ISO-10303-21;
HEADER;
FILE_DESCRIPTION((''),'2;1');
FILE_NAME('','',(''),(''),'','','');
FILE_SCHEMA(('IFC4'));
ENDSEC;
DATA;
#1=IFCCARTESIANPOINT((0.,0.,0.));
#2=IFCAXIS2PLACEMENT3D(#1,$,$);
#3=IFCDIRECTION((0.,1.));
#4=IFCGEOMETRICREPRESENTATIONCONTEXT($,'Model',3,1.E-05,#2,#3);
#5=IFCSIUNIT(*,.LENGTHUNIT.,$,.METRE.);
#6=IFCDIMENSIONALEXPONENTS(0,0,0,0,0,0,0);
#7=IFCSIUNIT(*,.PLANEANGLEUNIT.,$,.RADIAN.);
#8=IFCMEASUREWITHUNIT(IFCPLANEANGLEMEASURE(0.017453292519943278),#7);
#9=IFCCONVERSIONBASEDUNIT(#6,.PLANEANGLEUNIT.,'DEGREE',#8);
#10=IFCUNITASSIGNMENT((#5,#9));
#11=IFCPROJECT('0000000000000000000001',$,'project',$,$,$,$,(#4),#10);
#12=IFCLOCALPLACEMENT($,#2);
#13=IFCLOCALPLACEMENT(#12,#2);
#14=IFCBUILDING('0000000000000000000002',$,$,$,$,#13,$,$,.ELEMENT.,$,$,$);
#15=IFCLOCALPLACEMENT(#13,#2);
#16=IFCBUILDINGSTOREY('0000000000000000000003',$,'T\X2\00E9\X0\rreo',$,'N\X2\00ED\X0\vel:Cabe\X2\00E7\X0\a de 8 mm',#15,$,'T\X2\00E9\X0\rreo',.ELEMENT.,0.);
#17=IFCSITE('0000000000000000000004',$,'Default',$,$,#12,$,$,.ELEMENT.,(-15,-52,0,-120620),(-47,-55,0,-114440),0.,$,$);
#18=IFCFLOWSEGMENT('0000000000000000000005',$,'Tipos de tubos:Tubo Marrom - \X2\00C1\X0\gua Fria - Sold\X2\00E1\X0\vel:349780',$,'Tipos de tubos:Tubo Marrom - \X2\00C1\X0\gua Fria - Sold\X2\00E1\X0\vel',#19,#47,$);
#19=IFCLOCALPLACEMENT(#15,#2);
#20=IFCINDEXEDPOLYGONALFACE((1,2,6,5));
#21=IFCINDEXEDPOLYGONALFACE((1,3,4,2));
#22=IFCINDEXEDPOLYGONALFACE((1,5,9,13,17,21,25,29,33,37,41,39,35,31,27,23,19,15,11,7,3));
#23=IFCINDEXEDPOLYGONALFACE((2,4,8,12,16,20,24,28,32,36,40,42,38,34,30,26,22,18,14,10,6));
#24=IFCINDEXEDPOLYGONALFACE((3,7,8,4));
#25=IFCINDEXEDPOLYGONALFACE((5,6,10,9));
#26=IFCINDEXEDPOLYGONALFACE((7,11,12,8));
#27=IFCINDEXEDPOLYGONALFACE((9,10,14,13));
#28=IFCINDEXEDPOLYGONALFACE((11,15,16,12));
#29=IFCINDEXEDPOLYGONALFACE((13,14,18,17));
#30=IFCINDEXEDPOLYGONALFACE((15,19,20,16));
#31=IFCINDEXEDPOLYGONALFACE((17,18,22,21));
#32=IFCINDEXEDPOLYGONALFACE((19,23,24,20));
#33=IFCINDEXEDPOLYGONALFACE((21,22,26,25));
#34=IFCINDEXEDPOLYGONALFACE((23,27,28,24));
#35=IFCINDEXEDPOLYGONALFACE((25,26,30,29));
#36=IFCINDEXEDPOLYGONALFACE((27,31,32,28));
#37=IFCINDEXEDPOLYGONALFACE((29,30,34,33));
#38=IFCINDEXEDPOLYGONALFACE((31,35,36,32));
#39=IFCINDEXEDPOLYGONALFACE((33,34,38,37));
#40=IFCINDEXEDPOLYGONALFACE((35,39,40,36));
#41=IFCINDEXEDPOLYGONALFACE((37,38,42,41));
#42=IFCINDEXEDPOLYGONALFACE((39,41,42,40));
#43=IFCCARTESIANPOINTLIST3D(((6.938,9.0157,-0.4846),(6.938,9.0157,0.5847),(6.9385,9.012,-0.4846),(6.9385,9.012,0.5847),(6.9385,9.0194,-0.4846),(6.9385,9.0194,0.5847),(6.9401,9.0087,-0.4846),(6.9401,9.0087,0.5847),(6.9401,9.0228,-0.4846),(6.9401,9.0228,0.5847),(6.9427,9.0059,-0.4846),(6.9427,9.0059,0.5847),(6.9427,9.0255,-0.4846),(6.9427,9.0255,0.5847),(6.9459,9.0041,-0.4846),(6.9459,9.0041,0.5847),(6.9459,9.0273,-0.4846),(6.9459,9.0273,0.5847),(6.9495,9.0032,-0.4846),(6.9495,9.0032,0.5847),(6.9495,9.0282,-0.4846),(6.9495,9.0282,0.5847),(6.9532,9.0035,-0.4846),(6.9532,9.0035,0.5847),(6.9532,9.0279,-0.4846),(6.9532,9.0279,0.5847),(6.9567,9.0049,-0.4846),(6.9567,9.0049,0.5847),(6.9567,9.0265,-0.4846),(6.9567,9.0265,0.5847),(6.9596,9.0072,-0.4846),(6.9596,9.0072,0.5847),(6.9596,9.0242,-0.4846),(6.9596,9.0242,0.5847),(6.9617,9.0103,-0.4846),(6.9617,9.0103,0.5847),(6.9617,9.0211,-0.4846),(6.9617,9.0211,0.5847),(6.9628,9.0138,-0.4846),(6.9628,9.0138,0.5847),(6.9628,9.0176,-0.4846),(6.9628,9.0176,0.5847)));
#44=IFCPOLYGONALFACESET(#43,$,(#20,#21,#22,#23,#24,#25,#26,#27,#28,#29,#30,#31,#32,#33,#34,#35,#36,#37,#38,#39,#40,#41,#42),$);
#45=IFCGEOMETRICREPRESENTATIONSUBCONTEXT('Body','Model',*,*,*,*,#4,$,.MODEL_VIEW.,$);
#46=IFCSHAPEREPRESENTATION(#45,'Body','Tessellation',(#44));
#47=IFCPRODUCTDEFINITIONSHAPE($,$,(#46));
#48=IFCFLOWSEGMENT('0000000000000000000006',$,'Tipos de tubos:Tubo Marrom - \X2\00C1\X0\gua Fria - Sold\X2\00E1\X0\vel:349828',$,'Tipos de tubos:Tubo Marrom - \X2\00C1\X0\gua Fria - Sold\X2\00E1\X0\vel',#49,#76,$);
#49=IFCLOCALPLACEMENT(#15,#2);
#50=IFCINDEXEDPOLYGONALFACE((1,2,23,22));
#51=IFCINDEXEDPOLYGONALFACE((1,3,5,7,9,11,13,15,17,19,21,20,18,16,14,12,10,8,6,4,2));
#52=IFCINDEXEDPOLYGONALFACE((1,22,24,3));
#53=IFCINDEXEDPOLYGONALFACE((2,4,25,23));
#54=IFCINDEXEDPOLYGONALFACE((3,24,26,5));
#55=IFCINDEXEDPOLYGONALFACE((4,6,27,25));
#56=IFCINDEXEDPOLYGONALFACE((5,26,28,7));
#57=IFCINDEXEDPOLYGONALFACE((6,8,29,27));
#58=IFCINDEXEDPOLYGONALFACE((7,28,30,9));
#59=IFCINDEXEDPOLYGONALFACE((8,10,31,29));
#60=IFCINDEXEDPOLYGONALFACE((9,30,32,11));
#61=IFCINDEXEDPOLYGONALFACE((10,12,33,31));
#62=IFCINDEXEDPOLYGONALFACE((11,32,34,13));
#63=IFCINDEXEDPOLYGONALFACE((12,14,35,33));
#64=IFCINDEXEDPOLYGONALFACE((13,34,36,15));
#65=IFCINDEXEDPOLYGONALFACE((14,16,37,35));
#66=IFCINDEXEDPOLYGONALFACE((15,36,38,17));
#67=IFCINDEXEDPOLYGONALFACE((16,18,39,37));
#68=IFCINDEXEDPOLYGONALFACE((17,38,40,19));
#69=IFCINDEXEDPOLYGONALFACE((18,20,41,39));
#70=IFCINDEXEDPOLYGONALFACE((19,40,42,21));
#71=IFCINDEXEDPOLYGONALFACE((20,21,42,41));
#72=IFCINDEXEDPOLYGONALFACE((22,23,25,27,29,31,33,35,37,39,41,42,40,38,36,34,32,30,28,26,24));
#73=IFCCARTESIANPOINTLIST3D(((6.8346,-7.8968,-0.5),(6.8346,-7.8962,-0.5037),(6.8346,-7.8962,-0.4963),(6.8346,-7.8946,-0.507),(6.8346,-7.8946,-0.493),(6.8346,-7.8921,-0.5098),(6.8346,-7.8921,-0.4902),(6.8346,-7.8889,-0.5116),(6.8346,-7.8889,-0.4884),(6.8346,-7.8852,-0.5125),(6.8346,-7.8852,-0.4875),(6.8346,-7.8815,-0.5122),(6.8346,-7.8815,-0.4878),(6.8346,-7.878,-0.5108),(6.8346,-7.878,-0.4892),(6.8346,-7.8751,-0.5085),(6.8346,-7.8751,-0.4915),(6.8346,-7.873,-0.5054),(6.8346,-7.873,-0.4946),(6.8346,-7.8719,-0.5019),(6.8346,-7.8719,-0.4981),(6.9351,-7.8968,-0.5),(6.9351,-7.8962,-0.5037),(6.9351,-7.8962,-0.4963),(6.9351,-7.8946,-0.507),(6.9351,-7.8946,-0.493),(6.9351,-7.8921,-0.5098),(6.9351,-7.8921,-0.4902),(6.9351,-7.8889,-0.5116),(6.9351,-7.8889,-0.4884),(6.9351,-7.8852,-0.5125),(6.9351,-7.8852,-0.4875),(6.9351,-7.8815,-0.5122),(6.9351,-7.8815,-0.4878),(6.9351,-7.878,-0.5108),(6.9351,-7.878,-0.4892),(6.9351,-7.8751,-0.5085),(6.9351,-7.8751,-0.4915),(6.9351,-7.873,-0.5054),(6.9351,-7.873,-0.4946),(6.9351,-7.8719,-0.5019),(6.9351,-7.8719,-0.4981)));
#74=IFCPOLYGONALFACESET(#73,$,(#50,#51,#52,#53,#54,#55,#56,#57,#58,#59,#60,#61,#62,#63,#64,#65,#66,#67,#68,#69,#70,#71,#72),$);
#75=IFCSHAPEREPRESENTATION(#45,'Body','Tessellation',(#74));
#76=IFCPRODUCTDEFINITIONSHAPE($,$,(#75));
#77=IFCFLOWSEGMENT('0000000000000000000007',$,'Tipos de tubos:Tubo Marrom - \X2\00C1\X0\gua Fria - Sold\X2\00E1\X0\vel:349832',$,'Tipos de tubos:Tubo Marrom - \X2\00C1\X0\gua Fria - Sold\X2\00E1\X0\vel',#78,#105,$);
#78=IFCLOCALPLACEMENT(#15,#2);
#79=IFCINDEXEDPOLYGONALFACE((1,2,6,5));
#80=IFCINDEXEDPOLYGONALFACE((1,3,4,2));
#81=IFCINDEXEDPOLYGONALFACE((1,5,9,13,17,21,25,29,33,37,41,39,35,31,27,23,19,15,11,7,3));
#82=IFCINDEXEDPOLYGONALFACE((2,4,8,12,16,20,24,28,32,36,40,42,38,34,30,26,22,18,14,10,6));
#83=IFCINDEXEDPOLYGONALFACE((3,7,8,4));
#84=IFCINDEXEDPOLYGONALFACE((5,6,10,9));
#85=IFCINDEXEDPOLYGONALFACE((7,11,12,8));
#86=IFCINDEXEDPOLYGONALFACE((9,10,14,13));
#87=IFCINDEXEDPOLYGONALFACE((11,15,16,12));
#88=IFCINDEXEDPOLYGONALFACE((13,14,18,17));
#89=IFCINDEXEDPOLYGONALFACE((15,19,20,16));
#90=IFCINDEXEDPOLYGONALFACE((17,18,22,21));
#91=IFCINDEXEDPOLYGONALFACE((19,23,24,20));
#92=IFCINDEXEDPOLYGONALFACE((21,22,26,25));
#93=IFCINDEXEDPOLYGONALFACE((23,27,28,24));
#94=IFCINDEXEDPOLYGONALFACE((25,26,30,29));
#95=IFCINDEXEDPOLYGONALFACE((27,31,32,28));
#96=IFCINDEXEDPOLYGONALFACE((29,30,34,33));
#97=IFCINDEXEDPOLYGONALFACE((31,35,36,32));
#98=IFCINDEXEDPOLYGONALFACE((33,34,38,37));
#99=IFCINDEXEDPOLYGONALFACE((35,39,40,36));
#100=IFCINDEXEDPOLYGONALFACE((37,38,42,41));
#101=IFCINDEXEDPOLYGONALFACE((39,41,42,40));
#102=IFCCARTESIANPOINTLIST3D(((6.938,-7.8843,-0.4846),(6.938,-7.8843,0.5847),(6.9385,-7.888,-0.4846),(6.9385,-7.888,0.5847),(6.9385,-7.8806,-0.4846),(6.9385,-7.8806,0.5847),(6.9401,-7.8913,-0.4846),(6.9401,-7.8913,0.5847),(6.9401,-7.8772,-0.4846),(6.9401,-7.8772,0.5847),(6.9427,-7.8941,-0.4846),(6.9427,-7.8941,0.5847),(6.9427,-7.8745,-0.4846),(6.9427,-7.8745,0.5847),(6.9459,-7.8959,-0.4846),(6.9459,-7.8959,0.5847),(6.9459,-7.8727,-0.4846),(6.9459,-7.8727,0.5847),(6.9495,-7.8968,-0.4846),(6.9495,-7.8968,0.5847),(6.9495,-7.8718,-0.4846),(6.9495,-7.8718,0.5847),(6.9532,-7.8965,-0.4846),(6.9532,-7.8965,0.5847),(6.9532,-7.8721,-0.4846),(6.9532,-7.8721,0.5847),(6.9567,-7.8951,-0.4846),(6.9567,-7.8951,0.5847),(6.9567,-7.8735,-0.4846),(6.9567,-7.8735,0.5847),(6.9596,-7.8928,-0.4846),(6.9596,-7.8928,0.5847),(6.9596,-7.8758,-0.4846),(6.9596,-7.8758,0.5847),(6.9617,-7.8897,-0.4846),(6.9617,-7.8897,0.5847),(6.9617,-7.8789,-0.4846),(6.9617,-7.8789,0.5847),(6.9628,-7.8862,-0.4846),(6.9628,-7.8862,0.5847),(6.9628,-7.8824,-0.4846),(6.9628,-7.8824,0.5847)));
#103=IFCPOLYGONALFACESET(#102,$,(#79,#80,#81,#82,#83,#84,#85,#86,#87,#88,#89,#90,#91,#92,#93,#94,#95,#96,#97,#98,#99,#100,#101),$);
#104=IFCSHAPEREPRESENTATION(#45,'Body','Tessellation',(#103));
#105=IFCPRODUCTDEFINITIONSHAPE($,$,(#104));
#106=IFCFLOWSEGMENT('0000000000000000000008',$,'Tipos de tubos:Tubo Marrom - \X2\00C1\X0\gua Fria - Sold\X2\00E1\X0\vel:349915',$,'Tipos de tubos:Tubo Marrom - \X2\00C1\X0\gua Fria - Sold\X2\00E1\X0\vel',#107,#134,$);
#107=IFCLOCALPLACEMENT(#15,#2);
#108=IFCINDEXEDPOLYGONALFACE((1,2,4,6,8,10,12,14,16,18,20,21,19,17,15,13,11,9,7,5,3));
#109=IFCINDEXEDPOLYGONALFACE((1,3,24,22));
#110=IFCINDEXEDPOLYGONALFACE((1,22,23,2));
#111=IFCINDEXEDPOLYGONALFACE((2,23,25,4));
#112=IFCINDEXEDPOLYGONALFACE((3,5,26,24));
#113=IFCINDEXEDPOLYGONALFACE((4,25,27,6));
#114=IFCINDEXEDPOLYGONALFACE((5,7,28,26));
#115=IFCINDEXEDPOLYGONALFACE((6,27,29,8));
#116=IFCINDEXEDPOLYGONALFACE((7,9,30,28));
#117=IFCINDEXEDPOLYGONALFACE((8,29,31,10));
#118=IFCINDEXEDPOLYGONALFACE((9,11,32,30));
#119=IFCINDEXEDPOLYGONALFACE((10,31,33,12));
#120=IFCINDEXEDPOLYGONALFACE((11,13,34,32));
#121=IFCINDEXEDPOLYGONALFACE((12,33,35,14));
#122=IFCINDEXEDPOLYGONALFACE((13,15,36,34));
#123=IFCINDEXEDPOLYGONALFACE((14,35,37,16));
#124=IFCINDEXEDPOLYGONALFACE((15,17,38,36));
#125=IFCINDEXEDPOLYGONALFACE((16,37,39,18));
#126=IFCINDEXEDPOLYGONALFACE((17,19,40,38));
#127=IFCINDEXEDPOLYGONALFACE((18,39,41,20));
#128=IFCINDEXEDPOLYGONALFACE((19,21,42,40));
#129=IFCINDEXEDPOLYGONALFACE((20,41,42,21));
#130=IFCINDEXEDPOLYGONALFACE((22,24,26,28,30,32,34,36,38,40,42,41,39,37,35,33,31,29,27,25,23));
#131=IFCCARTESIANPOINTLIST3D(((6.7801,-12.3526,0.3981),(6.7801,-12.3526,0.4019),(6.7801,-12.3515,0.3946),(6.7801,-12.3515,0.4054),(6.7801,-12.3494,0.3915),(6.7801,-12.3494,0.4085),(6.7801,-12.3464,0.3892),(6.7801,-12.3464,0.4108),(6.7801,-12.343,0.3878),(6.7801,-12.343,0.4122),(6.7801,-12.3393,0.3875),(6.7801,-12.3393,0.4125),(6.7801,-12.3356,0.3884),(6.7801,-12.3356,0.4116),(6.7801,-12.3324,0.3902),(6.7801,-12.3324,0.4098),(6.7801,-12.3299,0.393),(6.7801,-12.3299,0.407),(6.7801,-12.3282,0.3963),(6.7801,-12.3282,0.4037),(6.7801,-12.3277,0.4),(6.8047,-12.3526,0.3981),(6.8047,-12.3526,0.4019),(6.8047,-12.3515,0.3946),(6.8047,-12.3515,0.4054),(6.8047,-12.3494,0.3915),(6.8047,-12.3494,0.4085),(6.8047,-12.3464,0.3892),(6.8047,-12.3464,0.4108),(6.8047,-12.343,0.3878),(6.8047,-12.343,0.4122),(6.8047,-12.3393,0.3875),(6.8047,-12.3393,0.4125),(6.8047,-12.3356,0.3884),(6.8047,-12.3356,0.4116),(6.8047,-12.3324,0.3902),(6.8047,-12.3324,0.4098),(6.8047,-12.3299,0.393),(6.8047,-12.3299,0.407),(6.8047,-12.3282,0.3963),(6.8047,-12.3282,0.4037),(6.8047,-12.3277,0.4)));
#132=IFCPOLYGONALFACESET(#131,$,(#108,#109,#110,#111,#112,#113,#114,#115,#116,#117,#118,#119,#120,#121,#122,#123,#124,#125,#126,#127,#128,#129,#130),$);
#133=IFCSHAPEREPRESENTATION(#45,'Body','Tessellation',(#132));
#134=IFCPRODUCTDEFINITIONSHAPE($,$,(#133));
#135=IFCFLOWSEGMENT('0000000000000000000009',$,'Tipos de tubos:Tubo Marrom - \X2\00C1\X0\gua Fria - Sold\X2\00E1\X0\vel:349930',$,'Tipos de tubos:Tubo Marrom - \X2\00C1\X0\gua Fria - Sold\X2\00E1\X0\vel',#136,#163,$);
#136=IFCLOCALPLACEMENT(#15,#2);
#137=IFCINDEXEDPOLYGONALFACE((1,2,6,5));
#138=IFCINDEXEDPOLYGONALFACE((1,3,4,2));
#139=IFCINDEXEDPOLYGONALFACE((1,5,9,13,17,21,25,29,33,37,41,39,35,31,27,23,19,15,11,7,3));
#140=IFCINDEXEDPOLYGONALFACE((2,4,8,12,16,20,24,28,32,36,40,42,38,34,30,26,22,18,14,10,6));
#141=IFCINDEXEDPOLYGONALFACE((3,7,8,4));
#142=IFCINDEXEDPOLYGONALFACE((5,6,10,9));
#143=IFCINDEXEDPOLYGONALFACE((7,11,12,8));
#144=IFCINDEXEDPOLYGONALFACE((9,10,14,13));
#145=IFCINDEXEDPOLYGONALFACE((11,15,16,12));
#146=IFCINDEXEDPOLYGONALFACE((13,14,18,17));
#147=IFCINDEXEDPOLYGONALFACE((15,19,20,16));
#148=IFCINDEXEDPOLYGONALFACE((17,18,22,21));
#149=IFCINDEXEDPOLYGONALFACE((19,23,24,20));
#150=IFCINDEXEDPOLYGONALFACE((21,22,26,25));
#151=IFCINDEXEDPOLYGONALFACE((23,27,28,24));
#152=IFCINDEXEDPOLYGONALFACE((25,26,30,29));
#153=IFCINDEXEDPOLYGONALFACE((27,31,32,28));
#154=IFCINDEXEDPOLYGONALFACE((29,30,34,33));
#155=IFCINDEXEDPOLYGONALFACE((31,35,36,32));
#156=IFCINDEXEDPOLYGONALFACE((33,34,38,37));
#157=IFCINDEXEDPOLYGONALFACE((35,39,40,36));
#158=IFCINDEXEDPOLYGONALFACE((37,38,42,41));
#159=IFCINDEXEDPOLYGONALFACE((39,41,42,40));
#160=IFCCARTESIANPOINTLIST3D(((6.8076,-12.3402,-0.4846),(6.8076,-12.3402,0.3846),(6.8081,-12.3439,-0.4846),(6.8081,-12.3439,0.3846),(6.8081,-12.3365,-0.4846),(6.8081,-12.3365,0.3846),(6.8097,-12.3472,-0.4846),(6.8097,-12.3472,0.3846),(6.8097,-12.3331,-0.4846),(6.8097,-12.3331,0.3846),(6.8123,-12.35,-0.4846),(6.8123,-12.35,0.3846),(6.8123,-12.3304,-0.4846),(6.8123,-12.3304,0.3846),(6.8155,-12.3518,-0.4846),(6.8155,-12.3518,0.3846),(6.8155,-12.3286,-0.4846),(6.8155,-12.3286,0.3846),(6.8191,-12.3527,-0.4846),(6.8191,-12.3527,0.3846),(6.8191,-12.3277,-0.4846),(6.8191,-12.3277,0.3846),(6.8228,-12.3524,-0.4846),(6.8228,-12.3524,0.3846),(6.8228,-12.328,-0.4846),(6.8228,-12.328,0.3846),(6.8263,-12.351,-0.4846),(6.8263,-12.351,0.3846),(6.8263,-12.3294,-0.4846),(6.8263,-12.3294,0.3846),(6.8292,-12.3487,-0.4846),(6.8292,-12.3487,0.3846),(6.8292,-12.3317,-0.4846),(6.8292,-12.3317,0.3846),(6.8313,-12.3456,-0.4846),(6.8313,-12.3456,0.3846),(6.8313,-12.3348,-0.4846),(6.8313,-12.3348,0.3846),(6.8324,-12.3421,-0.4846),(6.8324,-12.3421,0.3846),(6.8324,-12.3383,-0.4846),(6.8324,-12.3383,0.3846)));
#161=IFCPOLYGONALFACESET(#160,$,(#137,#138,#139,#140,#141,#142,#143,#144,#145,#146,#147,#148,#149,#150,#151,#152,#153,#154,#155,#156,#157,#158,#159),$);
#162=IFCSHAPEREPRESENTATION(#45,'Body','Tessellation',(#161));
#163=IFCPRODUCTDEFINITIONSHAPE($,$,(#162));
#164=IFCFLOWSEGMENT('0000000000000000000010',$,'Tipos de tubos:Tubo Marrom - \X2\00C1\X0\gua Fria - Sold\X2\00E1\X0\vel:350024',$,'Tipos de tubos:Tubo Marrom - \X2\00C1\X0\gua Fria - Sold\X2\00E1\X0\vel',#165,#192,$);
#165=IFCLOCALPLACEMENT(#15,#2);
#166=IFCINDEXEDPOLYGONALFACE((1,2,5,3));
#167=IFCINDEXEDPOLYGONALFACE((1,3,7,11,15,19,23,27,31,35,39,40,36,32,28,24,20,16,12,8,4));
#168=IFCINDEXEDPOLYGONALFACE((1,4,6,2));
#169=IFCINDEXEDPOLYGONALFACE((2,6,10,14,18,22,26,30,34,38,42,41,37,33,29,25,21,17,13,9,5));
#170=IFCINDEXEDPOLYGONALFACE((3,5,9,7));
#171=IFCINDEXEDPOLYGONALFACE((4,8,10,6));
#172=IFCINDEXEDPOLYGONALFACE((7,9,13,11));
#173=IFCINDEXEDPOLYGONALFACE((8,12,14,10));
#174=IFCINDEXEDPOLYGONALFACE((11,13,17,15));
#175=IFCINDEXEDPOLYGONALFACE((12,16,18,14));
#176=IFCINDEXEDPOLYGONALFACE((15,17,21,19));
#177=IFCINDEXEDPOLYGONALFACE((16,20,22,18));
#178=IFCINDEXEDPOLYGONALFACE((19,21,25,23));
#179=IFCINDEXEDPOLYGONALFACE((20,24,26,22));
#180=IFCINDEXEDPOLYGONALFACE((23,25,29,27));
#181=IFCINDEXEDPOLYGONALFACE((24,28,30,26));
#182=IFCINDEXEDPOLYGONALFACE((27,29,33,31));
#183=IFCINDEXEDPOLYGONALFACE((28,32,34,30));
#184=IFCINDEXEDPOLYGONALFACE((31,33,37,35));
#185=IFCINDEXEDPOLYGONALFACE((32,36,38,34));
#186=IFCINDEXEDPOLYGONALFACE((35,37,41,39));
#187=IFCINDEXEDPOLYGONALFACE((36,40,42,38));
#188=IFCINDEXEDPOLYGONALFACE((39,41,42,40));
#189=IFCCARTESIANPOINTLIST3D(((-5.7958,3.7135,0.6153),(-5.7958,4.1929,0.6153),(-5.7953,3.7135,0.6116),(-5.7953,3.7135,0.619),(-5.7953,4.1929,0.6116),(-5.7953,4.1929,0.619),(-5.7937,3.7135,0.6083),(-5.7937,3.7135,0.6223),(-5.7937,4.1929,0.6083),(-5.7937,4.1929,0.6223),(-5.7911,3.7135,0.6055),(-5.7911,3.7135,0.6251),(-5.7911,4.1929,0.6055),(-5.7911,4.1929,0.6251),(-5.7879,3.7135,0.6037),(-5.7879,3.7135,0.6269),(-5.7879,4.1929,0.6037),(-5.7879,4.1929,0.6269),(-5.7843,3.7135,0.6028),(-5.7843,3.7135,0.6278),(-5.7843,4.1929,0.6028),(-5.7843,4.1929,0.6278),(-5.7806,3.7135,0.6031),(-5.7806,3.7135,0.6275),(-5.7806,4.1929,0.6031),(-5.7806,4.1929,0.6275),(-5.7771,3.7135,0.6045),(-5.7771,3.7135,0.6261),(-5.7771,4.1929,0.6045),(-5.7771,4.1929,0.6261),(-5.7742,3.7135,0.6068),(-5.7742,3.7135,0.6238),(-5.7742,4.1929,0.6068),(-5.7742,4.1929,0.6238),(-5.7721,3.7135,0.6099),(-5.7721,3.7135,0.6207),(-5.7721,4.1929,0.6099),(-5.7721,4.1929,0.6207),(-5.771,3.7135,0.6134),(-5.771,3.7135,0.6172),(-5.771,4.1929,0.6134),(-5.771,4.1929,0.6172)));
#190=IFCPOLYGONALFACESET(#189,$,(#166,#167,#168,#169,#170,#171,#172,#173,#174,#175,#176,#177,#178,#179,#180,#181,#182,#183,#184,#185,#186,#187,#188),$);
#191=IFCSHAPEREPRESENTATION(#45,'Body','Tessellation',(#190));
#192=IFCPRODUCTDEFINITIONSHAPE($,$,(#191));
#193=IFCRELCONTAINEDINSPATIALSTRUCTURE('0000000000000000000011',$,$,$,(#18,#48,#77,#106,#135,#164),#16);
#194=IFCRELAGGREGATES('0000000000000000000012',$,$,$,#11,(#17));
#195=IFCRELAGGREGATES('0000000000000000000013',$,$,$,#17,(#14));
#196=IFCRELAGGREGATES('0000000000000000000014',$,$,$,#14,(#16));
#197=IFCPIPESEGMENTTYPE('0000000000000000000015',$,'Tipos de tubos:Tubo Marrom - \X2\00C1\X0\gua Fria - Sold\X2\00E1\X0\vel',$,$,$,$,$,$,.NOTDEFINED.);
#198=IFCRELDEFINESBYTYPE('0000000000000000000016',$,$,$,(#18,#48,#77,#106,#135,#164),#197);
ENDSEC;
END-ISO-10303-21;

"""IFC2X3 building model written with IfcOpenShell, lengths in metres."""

from ifc_helpers import new_model, entity, si_unit, converted_unit, direction, frame, frame_2d, origin, origin_2d_with_axis, place, context, subcontext, project, spatial, circle, extrude, type_object, element, save


model = new_model("IFC2X3")

# Units and contexts
model_context = context("Model", 3, precision=1e-05, world=origin(), true_north=direction((0.0, 1.0)))
body_context = subcontext(model_context, "Body", "Model", "MODEL_VIEW")
ifc_project = project(units=[si_unit("LENGTHUNIT", "METRE"), converted_unit("PLANEANGLEUNIT", "DEGREE", entity("IfcPlaneAngleMeasure", 0.017453292519943278), si_unit("PLANEANGLEUNIT", "RADIAN"), dimensions=[0, 0, 0, 0, 0, 0, 0])], contexts=[model_context])

# Site, building, storey
site_placement = place(None, origin())
site = spatial("IfcSite", under=ifc_project, at=site_placement, Name="Default", CompositionType="ELEMENT", RefLatitude=(-15, -52, 0, -120620), RefLongitude=(-47, -55, 0, -114440), RefElevation=0.0)
building_placement = place(site_placement, origin())
building = spatial("IfcBuilding", under=site, at=building_placement, CompositionType="ELEMENT")
storey_placement = place(building_placement, origin())
storey = spatial("IfcBuildingStorey", under=building, at=storey_placement, Name="Térreo", ObjectType="Nível:Cabeça de 8 mm", LongName="Térreo", CompositionType="ELEMENT", Elevation=0.0)

# Flow segments
pipe_segment_type = type_object("IfcPipeSegmentType", Name="Tipos de tubos:Tubo Marrom - Água Fria - Soldável", PredefinedType="NOTDEFINED")
flow_segment_1_placement = place(storey_placement, origin())
element("IfcFlowSegment", 1, at=flow_segment_1_placement, inside=storey, type_object=pipe_segment_type, Name="Tipos de tubos:Tubo Marrom - Água Fria - Soldável:349780", ObjectType="Tipos de tubos:Tubo Marrom - Água Fria - Soldável", context=body_context, shape_type="SweptSolid", body=[
    extrude(circle(Radius=0.0125, at=frame_2d((0.0, 0.0), x_axis=(1.0, 0.0))), frame((6.9505, 9.0157, -0.4846), z_axis=(0.0, 0.0, 1.0), x_axis=(-1.0, 0.0, 0.0)), (0.0, 0.0, 1.0), 1.0693),
])
flow_segment_2_placement = place(storey_placement, origin())
element("IfcFlowSegment", 2, at=flow_segment_2_placement, inside=storey, type_object=pipe_segment_type, Name="Tipos de tubos:Tubo Marrom - Água Fria - Soldável:349828", ObjectType="Tipos de tubos:Tubo Marrom - Água Fria - Soldável", context=body_context, shape_type="SweptSolid", body=[
    extrude(circle(Radius=0.0125, at=origin_2d_with_axis()), frame((6.8346, -7.8843, -0.5), z_axis=(1.0, 0.0, 0.0), x_axis=(0.0, -1.0, 0.0)), (0.0, 0.0, 1.0), 0.1005),
])
flow_segment_3_placement = place(storey_placement, origin())
element("IfcFlowSegment", 3, at=flow_segment_3_placement, inside=storey, type_object=pipe_segment_type, Name="Tipos de tubos:Tubo Marrom - Água Fria - Soldável:349832", ObjectType="Tipos de tubos:Tubo Marrom - Água Fria - Soldável", context=body_context, shape_type="SweptSolid", body=[
    extrude(circle(Radius=0.0125, at=origin_2d_with_axis()), frame((6.9505, -7.8843, -0.4846), z_axis=(0.0, 0.0, 1.0), x_axis=(-1.0, 0.0, 0.0)), (0.0, 0.0, 1.0), 1.0693),
])
flow_segment_4_placement = place(storey_placement, origin())
element("IfcFlowSegment", 4, at=flow_segment_4_placement, inside=storey, type_object=pipe_segment_type, Name="Tipos de tubos:Tubo Marrom - Água Fria - Soldável:349915", ObjectType="Tipos de tubos:Tubo Marrom - Água Fria - Soldável", context=body_context, shape_type="SweptSolid", body=[
    extrude(circle(Radius=0.0125, at=origin_2d_with_axis()), frame((6.7801, -12.3402, 0.4), z_axis=(1.0, 0.0, 0.0), x_axis=(0.0, 1.0, 0.0)), (0.0, 0.0, 1.0), 0.0246),
])
flow_segment_5_placement = place(storey_placement, origin())
element("IfcFlowSegment", 5, at=flow_segment_5_placement, inside=storey, type_object=pipe_segment_type, Name="Tipos de tubos:Tubo Marrom - Água Fria - Soldável:349930", ObjectType="Tipos de tubos:Tubo Marrom - Água Fria - Soldável", context=body_context, shape_type="SweptSolid", body=[
    extrude(circle(Radius=0.0125, at=origin_2d_with_axis()), frame((6.8201, -12.3402, -0.4846), z_axis=(0.0, 0.0, 1.0), x_axis=(-1.0, 0.0, 0.0)), (0.0, 0.0, 1.0), 0.8692),
])
flow_segment_6_placement = place(storey_placement, origin())
element("IfcFlowSegment", 6, at=flow_segment_6_placement, inside=storey, type_object=pipe_segment_type, Name="Tipos de tubos:Tubo Marrom - Água Fria - Soldável:350024", ObjectType="Tipos de tubos:Tubo Marrom - Água Fria - Soldável", context=body_context, shape_type="SweptSolid", body=[
    extrude(circle(Radius=0.0125, at=frame_2d((0.0, 0.0), x_axis=(1.0, 0.0))), frame((-5.7833, 3.7135, 0.6153), z_axis=(0.0, 1.0, 0.0), x_axis=(-1.0, 0.0, 0.0)), (0.0, 0.0, 1.0), 0.4794),
])

save(model, "model.ifc")
